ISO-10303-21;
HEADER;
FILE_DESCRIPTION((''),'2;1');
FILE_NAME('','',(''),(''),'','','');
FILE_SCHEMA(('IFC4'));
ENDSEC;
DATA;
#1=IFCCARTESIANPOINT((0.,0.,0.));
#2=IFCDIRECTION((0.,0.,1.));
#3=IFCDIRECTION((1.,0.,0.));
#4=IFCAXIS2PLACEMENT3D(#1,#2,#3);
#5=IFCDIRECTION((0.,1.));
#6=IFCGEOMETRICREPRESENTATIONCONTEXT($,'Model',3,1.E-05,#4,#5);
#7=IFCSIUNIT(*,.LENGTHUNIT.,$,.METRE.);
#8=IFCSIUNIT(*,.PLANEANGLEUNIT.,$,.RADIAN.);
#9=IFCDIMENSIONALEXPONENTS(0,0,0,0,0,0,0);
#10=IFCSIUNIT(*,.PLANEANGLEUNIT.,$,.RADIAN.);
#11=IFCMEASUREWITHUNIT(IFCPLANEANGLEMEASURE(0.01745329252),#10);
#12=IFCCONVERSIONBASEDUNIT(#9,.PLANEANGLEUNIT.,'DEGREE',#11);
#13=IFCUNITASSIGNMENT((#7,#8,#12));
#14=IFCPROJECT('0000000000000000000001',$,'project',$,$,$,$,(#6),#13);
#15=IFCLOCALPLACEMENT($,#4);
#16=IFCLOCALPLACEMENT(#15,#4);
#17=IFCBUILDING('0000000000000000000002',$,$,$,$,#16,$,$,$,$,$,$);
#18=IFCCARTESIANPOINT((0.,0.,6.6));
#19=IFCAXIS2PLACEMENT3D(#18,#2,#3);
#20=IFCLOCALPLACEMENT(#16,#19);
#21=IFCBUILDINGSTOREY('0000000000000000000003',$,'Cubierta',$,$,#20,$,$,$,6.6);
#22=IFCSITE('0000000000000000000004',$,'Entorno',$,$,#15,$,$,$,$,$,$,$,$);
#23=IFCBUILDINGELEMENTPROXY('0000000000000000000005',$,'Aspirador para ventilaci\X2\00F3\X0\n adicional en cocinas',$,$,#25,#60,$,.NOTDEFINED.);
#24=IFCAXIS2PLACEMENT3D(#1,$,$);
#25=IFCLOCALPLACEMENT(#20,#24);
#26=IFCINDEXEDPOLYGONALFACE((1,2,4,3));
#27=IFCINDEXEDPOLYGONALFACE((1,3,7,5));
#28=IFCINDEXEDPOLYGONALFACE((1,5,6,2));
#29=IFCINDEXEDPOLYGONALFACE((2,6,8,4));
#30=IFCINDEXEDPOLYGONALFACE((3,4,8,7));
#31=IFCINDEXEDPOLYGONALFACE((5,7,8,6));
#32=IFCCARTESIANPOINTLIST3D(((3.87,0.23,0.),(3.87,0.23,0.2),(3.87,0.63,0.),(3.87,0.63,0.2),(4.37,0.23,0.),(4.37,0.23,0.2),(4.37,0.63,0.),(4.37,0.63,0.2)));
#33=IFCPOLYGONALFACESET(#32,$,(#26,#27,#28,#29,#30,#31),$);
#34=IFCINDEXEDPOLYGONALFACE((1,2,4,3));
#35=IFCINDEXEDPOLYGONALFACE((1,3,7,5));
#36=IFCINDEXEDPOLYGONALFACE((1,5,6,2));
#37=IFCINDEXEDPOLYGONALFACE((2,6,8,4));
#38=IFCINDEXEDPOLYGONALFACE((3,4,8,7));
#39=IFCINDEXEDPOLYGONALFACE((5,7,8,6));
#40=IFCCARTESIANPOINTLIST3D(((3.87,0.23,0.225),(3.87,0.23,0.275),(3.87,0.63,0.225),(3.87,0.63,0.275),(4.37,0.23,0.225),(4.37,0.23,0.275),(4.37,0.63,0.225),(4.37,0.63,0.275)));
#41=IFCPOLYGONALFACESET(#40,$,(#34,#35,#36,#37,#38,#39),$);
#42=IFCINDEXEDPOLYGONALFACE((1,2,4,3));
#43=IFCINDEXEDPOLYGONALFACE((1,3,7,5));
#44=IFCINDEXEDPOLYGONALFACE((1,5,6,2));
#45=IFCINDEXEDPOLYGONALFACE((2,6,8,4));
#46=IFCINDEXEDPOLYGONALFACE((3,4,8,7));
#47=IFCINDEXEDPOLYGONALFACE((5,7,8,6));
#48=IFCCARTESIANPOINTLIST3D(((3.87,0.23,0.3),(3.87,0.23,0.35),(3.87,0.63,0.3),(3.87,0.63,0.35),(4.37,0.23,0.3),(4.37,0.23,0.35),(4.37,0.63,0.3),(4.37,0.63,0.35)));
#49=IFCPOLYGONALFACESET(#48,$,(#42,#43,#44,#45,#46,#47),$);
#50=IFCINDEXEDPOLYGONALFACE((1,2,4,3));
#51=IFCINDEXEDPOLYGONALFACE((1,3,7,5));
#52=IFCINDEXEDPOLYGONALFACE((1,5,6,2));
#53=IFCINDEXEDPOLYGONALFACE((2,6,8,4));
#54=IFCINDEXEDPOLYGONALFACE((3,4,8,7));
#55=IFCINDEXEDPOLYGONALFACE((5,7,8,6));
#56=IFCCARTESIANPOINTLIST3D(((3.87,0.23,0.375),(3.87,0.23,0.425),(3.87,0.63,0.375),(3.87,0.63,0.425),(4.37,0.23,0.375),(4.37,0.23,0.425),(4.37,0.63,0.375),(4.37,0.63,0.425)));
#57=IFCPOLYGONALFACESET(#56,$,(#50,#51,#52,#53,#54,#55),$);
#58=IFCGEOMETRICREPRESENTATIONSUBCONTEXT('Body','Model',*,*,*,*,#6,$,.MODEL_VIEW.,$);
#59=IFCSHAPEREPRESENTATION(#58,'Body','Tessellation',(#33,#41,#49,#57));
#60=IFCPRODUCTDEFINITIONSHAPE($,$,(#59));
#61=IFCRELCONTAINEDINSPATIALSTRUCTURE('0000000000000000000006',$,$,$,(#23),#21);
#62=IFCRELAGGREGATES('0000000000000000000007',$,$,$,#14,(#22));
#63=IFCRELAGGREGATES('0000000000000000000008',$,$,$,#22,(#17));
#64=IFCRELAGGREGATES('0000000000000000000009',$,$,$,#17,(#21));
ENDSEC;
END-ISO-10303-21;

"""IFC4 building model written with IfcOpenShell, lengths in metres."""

from ifc_helpers import new_model, entity, si_unit, converted_unit, direction, frame, origin_with_axes, place, context, subcontext, project, spatial, polyline, outline, extrude, element, save


model = new_model("IFC4")

# Units and contexts
model_context = context("Model", 3, precision=1e-05, world=origin_with_axes(), true_north=direction((0.0, 1.0)))
body_context = subcontext(model_context, "Body", "Model", "MODEL_VIEW")
ifc_project = project(units=[si_unit("LENGTHUNIT", "METRE"), si_unit("PLANEANGLEUNIT", "RADIAN"), converted_unit("PLANEANGLEUNIT", "DEGREE", entity("IfcPlaneAngleMeasure", 0.01745329252), si_unit("PLANEANGLEUNIT", "RADIAN"), dimensions=[0, 0, 0, 0, 0, 0, 0])], contexts=[model_context])

# Site, building, storey
site_placement = place(None, origin_with_axes())
site = spatial("IfcSite", under=ifc_project, at=site_placement, Name="Entorno")
building_placement = place(site_placement, origin_with_axes())
building = spatial("IfcBuilding", under=site, at=building_placement)
storey_placement = place(building_placement, frame((0.0, 0.0, 6.6), z_axis=(0.0, 0.0, 1.0), x_axis=(1.0, 0.0, 0.0)))
storey = spatial("IfcBuildingStorey", under=building, at=storey_placement, Name="Cubierta", Elevation=6.6)

# Building element proxy
proxy_1_placement = place(storey_placement, frame((0.0, 0.0, -6.6), z_axis=(0.0, 0.0, 1.0), x_axis=(1.0, 0.0, 0.0)))
element("IfcBuildingElementProxy", 1, at=proxy_1_placement, inside=storey, Name="Aspirador para ventilación adicional en cocinas", PredefinedType="NOTDEFINED", context=body_context, shape_type="Brep", body=[
    extrude(outline(polyline([(-0.25, -0.2), (0.25, -0.2), (0.25, 0.2), (-0.25, 0.2), (-0.25, -0.2)])), frame((4.12, 0.43, 6.6), z_axis=(0.0, 0.0, 1.0), x_axis=(-1.0, 0.0, 0.0)), (0.0, 0.0, 1.0), 0.2),
    extrude(outline(polyline([(-0.25, -0.2), (0.25, -0.2), (0.25, 0.2), (-0.25, 0.2), (-0.25, -0.2)])), frame((4.12, 0.43, 6.825), z_axis=(0.0, 0.0, 1.0), x_axis=(-1.0, 0.0, 0.0)), (0.0, 0.0, 1.0), 0.05),
    extrude(outline(polyline([(-0.25, -0.2), (0.25, -0.2), (0.25, 0.2), (-0.25, 0.2), (-0.25, -0.2)])), frame((4.12, 0.43, 6.9), z_axis=(0.0, 0.0, 1.0), x_axis=(-1.0, 0.0, 0.0)), (0.0, 0.0, 1.0), 0.05),
    extrude(outline(polyline([(-0.25, -0.2), (0.25, -0.2), (0.25, 0.2), (-0.25, 0.2), (-0.25, -0.2)])), frame((4.12, 0.43, 6.975), z_axis=(0.0, 0.0, 1.0), x_axis=(-1.0, 0.0, 0.0)), (0.0, 0.0, 1.0), 0.05),
])

save(model, "model.ifc")
